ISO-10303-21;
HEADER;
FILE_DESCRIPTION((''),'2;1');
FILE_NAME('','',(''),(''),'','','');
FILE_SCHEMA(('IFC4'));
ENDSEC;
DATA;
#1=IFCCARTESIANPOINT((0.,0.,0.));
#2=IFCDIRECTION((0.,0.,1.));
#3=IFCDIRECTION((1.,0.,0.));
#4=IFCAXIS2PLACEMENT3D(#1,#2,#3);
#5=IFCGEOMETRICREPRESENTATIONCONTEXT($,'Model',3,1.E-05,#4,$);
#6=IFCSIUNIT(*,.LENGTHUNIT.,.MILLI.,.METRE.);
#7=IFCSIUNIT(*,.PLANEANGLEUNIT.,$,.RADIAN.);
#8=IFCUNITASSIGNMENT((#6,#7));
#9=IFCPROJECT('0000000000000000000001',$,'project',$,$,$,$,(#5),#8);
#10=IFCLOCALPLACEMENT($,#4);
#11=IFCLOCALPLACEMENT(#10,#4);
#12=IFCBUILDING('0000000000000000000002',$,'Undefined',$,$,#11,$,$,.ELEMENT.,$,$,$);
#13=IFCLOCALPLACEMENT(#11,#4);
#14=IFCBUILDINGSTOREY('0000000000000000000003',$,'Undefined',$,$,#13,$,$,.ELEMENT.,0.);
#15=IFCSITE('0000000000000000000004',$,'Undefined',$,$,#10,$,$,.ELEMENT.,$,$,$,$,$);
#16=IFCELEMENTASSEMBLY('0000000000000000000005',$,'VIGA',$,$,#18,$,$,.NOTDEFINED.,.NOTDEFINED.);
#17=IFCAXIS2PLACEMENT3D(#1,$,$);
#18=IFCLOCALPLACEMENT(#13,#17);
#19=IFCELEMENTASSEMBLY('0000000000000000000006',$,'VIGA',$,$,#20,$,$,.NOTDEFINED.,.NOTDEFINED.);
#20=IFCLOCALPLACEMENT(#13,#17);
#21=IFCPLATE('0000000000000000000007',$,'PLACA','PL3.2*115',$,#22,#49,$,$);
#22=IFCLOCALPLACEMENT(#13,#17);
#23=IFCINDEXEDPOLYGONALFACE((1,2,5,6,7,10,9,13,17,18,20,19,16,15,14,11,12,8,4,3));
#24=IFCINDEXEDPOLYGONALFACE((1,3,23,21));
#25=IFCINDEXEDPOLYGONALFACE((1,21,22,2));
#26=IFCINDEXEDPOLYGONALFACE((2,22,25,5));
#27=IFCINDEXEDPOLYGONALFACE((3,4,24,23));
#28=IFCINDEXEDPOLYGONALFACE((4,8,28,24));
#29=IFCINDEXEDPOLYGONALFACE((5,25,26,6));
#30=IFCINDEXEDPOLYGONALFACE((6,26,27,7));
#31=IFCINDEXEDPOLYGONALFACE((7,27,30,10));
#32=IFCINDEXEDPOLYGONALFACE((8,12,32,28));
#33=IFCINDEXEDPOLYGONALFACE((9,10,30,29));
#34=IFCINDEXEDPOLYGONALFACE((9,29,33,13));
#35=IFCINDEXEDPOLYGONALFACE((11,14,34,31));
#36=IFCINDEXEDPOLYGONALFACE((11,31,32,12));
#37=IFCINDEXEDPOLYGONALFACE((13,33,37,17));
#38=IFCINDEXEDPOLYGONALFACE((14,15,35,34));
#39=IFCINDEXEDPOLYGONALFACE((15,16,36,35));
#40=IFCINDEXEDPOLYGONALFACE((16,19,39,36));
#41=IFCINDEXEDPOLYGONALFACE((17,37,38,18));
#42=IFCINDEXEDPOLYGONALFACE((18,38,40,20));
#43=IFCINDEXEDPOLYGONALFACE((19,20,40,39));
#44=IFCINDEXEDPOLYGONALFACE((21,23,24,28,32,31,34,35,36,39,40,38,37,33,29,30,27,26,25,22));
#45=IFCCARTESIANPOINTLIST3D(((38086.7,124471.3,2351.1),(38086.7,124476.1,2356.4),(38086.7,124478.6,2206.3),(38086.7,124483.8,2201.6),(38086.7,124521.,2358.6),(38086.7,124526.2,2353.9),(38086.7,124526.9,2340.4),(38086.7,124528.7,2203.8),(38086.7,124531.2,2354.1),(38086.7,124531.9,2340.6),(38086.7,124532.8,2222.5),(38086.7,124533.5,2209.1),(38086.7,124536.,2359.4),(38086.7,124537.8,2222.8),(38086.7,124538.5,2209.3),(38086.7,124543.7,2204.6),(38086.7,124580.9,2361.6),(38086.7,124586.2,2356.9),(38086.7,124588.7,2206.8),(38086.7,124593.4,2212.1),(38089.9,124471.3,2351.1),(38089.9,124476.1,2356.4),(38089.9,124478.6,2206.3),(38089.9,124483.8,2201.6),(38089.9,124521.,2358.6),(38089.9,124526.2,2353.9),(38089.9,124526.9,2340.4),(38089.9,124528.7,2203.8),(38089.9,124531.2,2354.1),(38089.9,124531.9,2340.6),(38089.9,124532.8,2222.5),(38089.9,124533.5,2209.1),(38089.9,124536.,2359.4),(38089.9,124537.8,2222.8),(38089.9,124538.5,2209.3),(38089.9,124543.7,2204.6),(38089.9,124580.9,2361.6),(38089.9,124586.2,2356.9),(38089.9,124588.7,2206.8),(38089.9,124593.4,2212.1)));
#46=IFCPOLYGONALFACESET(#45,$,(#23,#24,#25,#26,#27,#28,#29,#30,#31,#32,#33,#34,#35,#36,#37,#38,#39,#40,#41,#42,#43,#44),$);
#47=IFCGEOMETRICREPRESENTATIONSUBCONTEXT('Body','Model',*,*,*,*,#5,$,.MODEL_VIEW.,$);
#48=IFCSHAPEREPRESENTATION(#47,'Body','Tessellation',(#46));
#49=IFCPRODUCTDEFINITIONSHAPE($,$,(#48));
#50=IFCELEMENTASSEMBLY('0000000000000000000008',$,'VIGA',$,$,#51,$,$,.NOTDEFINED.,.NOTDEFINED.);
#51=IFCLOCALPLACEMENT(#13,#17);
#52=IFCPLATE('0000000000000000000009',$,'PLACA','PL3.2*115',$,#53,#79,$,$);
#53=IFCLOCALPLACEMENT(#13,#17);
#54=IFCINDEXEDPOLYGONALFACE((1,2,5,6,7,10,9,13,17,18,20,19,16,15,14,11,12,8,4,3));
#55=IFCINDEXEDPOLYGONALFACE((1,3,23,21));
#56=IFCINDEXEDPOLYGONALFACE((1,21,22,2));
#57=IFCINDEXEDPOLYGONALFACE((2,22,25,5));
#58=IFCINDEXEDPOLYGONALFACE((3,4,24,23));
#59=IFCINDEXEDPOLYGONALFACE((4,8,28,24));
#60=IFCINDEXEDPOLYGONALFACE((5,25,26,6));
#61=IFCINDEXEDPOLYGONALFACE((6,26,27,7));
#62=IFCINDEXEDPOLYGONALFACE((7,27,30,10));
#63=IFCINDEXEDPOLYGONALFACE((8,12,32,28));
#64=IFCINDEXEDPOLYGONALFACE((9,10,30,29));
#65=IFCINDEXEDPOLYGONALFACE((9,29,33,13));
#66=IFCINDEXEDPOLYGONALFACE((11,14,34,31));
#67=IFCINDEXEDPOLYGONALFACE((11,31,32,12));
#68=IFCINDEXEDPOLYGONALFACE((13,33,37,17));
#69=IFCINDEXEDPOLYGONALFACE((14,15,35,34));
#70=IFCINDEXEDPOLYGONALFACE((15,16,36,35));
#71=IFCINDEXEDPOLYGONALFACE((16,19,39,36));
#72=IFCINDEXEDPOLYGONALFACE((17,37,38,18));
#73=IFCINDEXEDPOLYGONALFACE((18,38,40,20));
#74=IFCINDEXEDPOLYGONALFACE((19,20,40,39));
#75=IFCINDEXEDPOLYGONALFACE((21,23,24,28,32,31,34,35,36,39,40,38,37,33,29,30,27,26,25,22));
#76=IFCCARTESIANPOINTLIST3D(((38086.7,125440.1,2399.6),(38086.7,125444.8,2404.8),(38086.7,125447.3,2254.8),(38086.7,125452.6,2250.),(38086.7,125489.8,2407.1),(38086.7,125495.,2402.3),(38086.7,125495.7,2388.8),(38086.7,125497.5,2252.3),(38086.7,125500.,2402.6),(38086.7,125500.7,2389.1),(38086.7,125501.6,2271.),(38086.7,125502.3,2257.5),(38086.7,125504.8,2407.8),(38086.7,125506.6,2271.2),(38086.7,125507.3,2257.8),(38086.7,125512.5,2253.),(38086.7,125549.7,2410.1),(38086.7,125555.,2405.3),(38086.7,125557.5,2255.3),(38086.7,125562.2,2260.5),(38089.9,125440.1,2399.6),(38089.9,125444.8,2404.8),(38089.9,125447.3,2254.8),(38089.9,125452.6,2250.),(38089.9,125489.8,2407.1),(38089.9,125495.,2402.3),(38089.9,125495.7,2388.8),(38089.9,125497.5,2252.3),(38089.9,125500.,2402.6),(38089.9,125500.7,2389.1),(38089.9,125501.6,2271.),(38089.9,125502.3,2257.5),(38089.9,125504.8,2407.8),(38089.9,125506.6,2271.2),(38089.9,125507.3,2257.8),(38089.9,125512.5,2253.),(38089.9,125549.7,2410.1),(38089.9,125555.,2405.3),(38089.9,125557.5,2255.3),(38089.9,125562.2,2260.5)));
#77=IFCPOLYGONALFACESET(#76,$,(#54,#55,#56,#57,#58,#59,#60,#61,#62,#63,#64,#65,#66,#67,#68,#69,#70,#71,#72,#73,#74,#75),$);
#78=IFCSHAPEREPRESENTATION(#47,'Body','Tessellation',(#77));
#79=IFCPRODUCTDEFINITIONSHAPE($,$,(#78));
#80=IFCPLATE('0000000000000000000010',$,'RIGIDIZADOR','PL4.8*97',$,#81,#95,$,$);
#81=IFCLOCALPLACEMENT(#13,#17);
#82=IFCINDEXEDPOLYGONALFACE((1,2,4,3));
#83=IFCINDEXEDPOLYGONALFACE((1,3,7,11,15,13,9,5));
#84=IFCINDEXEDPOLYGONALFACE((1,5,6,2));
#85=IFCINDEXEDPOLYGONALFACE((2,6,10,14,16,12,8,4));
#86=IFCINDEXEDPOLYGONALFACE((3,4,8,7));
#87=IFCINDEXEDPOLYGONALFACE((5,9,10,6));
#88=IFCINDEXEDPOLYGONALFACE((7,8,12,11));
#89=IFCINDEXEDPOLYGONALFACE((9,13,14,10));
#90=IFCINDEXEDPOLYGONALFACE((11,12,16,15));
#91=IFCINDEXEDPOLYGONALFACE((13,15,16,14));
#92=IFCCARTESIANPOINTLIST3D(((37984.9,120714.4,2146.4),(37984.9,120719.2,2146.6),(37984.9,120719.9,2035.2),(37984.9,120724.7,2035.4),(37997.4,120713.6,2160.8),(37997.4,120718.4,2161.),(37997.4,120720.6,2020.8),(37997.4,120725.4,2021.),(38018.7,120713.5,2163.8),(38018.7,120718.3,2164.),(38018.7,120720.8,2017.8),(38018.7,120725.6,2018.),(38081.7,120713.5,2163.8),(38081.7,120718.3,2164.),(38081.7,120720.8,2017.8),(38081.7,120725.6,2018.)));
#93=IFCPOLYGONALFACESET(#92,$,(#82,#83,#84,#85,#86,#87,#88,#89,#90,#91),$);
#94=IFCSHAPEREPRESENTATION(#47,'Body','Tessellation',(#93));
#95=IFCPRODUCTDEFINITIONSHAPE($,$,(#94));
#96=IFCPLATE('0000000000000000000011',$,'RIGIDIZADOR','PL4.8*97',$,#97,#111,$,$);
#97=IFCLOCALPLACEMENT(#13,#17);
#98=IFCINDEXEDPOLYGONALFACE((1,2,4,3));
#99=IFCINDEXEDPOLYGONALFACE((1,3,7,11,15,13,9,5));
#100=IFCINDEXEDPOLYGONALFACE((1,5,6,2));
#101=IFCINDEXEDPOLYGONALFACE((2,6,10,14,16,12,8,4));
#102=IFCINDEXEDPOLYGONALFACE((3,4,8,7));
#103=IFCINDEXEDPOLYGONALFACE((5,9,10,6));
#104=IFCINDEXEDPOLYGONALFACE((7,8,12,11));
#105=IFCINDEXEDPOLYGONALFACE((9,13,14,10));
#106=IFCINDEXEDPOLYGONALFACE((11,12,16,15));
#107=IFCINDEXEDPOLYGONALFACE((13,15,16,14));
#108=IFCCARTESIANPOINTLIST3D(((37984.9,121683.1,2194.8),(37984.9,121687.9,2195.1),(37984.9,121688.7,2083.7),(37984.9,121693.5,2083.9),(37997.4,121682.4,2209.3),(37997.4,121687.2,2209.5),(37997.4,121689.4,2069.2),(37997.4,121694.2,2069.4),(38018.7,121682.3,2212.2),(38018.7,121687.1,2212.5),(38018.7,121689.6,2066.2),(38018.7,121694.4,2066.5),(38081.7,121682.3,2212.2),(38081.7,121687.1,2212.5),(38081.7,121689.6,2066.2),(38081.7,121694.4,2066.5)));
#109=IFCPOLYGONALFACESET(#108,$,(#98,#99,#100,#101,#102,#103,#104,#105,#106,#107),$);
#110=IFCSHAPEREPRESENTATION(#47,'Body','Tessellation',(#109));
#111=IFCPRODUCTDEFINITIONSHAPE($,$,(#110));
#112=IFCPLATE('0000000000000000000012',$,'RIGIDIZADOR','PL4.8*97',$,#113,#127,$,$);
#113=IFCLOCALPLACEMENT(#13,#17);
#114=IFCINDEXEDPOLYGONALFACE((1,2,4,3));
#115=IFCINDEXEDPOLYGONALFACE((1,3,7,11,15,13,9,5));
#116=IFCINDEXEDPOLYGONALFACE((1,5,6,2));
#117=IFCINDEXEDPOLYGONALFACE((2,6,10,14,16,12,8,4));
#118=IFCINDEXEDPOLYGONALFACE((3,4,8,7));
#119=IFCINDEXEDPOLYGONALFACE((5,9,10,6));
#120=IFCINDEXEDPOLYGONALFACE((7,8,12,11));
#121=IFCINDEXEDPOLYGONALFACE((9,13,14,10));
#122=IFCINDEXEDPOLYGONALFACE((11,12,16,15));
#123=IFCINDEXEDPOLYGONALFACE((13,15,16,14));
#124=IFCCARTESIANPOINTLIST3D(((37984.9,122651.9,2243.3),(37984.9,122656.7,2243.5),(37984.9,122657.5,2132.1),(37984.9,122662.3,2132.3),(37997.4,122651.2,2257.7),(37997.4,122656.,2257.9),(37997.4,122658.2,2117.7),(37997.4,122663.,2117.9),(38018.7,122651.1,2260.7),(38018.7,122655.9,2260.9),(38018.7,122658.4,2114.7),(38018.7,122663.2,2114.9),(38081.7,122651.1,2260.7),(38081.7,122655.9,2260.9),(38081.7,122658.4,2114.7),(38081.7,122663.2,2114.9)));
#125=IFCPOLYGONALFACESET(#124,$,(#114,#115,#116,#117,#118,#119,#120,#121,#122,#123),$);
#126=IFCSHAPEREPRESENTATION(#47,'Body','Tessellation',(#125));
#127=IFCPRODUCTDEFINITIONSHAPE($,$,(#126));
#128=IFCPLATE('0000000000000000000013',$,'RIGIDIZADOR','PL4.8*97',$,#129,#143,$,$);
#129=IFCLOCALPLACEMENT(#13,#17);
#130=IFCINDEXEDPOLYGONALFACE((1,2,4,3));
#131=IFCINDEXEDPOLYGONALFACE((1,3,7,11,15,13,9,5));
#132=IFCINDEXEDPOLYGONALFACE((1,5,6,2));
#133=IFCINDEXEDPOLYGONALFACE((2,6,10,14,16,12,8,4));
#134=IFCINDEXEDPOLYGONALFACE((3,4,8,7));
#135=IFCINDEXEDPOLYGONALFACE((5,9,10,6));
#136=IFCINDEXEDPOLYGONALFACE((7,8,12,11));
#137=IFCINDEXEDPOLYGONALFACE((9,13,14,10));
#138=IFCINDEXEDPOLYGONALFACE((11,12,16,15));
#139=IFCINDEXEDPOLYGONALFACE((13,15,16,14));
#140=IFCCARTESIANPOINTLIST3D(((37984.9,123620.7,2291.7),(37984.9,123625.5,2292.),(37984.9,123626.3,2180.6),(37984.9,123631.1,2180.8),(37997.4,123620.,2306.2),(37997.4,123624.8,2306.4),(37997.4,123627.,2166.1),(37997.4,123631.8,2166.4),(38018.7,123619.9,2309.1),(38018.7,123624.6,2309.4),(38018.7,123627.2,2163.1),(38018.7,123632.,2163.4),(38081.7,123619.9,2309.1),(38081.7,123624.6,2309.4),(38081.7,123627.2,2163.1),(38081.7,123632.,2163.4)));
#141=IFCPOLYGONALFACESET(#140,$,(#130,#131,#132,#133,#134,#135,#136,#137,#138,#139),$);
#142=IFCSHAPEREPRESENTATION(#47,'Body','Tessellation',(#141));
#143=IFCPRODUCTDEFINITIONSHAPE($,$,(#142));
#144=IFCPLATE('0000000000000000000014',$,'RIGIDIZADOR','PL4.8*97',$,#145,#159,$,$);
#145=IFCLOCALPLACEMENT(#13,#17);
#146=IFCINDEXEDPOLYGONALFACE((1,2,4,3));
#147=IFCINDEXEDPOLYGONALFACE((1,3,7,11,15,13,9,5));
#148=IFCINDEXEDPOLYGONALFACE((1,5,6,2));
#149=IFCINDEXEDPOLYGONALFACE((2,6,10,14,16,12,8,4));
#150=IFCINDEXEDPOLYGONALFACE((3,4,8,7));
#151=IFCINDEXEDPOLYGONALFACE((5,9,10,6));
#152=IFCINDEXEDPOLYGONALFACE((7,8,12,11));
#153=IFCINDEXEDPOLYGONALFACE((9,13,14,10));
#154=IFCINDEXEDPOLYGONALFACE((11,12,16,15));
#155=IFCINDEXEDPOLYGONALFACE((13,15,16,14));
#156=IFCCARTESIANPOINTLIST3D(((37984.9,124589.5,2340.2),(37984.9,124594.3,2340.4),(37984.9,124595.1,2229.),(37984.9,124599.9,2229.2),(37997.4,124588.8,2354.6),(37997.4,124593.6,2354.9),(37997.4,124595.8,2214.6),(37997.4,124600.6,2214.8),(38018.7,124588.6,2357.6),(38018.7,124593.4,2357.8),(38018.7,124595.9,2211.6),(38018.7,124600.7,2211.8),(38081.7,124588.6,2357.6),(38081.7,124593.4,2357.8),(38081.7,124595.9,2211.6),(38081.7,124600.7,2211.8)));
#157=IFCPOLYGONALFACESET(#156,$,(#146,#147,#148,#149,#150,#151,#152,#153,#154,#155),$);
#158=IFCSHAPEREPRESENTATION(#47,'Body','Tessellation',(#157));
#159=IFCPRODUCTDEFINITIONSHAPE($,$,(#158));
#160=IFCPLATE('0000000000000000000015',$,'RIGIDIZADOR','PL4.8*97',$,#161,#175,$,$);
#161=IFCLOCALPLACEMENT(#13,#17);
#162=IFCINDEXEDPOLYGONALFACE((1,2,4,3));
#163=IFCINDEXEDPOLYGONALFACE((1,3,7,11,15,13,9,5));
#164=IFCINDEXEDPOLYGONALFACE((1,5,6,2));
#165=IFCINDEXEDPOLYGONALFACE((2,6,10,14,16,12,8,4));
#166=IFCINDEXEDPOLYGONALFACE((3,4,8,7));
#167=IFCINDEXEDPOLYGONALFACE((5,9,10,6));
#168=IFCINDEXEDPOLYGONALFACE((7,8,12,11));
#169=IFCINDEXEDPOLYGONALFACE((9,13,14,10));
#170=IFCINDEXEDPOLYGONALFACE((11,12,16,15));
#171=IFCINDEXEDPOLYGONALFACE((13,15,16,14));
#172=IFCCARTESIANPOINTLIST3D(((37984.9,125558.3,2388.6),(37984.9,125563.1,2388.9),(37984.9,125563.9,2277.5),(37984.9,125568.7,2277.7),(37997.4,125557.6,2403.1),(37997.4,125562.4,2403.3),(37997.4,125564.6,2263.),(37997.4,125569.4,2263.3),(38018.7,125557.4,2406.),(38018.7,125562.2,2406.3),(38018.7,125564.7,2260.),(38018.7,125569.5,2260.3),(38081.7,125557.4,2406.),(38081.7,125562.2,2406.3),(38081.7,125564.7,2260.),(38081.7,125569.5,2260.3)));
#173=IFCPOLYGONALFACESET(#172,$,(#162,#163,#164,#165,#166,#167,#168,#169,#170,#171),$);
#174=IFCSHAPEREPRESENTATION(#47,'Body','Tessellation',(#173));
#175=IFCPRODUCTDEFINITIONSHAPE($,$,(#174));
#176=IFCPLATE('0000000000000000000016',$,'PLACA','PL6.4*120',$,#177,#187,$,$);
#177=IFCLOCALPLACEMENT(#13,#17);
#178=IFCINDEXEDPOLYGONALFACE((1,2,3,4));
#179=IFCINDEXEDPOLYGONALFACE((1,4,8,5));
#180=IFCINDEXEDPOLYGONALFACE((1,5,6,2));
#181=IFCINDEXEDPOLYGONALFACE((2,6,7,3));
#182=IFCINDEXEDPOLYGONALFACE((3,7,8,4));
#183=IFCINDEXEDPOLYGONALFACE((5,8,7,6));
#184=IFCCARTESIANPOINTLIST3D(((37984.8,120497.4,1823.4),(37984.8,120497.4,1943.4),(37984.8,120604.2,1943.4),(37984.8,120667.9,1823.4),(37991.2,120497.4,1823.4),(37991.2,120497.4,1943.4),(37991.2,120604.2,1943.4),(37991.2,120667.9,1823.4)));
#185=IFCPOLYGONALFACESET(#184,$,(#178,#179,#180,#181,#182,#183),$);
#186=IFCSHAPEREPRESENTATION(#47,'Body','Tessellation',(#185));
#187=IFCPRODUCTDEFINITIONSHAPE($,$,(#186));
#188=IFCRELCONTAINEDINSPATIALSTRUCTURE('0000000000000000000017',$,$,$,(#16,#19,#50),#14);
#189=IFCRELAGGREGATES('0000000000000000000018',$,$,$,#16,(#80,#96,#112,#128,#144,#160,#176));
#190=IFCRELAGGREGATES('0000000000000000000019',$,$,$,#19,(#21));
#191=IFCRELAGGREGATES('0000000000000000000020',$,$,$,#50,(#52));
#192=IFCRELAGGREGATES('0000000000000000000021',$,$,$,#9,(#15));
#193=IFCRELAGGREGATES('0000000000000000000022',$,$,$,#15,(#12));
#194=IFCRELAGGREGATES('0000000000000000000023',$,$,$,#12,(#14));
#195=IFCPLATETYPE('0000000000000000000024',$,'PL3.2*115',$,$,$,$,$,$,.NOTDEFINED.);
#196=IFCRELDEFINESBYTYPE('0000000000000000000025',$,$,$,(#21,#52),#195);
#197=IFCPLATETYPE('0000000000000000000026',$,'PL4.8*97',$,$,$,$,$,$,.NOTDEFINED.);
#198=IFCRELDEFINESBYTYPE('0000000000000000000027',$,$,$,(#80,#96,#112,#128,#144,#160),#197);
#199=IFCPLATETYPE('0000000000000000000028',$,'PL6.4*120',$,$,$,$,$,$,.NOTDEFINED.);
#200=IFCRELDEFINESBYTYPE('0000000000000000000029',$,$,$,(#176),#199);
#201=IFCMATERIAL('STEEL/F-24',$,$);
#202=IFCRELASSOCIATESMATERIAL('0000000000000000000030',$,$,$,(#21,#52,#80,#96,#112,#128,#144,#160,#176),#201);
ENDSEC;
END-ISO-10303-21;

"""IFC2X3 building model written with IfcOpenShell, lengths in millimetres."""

from ifc_helpers import new_model, si_unit, frame, origin_with_axes, place, context, subcontext, project, spatial, polyline, outline, extrude, material, type_object, element, aggregate, save


model = new_model("IFC2X3")

# Units and contexts
model_context = context("Model", 3, precision=1e-05, world=origin_with_axes())
body_context = subcontext(model_context, "Body", "Model", "MODEL_VIEW")
ifc_project = project(units=[si_unit("LENGTHUNIT", "METRE", prefix="MILLI"), si_unit("PLANEANGLEUNIT", "RADIAN")], contexts=[model_context])

# Site, building, storey
site_placement = place(None, origin_with_axes())
site = spatial("IfcSite", under=ifc_project, at=site_placement, Name="Undefined", CompositionType="ELEMENT")
building_placement = place(site_placement, origin_with_axes())
building = spatial("IfcBuilding", under=site, at=building_placement, Name="Undefined", CompositionType="ELEMENT")
storey_placement = place(building_placement, origin_with_axes())
storey = spatial("IfcBuildingStorey", under=building, at=storey_placement, Name="Undefined", CompositionType="ELEMENT", Elevation=0.0)

# Element assembly
assembly_1_placement = place(storey_placement, origin_with_axes())
assembly_1 = element("IfcElementAssembly", 1, at=assembly_1_placement, inside=storey, Name="VIGA", AssemblyPlace="NOTDEFINED", PredefinedType="NOTDEFINED")
ifc_material_1 = material(Name="STEEL/F-24")

# Shared definitions
plate_type_1 = type_object("IfcPlateType", Name="PL3.2*115", PredefinedType="NOTDEFINED")

# Element assemblies, plates
assembly_2_placement = place(storey_placement, origin_with_axes())
assembly_2 = element("IfcElementAssembly", 2, at=assembly_2_placement, inside=storey, Name="VIGA", AssemblyPlace="NOTDEFINED", PredefinedType="NOTDEFINED")
plate_1_placement = place(assembly_2_placement, frame((38088.3, 124471.1, 2356.1), z_axis=(-1.0, 0.0, 0.0), x_axis=(0.0, 0.998752, 0.04995)))
plate_1 = element("IfcPlate", 3, at=plate_1_placement, type_object=plate_type_1, material=ifc_material_1, Name="PLACA", Description="PL3.2*115", context=body_context, shape_type="SweptSolid", body=[
    extrude(outline(polyline([(0.0, 5.0), (5.0, 0.0), (50.0, 0.0), (55.0, 5.0), (55.0, 18.5), (60.0, 18.5), (60.0, 5.0), (65.0, 0.0), (110.0, 0.0), (115.0, 5.0), (115.0, 150.0), (110.0, 155.0), (65.0, 155.0), (60.0, 150.0), (60.0, 136.5), (55.0, 136.5), (55.0, 150.0), (50.0, 155.0), (5.0, 155.0), (0.0, 150.0), (0.0, 5.0)])), frame((0.0, 0.0, -1.6), z_axis=(0.0, 0.0, 1.0), x_axis=(1.0, 0.0, 0.0)), (0.0, 0.0, 1.0), 3.2),
])
assembly_3_placement = place(storey_placement, origin_with_axes())
assembly_3 = element("IfcElementAssembly", 4, at=assembly_3_placement, inside=storey, Name="VIGA", AssemblyPlace="NOTDEFINED", PredefinedType="NOTDEFINED")
plate_2_placement = place(assembly_3_placement, frame((38088.3, 125439.9, 2404.6), z_axis=(-1.0, 0.0, 0.0), x_axis=(0.0, 0.998752, 0.04995)))
plate_2 = element("IfcPlate", 5, at=plate_2_placement, type_object=plate_type_1, material=ifc_material_1, Name="PLACA", Description="PL3.2*115", context=body_context, shape_type="SweptSolid", body=[
    extrude(outline(polyline([(0.0, 5.0), (5.0, 0.0), (50.0, 0.0), (55.0, 5.0), (55.0, 18.5), (60.0, 18.5), (60.0, 5.0), (65.0, 0.0), (110.0, 0.0), (115.0, 5.0), (115.0, 150.0), (110.0, 155.0), (65.0, 155.0), (60.0, 150.0), (60.0, 136.5), (55.0, 136.5), (55.0, 150.0), (50.0, 155.0), (5.0, 155.0), (0.0, 150.0), (0.0, 5.0)])), frame((0.0, 0.0, -1.6), z_axis=(0.0, 0.0, 1.0), x_axis=(1.0, 0.0, 0.0)), (0.0, 0.0, 1.0), 3.2),
])

# Plates
plate_type_2 = type_object("IfcPlateType", Name="PL4.8*97", PredefinedType="NOTDEFINED")
plate_3_placement = place(assembly_1_placement, frame((38081.7, 120715.9, 2163.9), z_axis=(0.0, -0.998752, -0.04995), x_axis=(-1.0, 0.0, 0.0)))
plate_3 = element("IfcPlate", 6, at=plate_3_placement, type_object=plate_type_2, material=ifc_material_1, Name="RIGIDIZADOR", Description="PL4.8*97", context=body_context, shape_type="SweptSolid", body=[
    extrude(outline(polyline([(0.0, 0.0), (63.0, 0.0), (84.3, 3.0), (96.8, 17.4), (96.8, 128.7), (84.3, 143.2), (63.0, 146.2), (0.0, 146.2), (0.0, 0.0)])), frame((0.0, 0.0, -2.4), z_axis=(0.0, 0.0, 1.0), x_axis=(1.0, 0.0, 0.0)), (0.0, 0.0, 1.0), 4.8),
])
plate_4_placement = place(assembly_1_placement, frame((38081.7, 121684.7, 2212.4), z_axis=(0.0, -0.998752, -0.04995), x_axis=(-1.0, 0.0, 0.0)))
plate_4 = element("IfcPlate", 7, at=plate_4_placement, type_object=plate_type_2, material=ifc_material_1, Name="RIGIDIZADOR", Description="PL4.8*97", context=body_context, shape_type="SweptSolid", body=[
    extrude(outline(polyline([(0.0, 0.0), (63.0, 0.0), (84.3, 3.0), (96.8, 17.4), (96.8, 128.7), (84.3, 143.2), (63.0, 146.2), (0.0, 146.2), (0.0, 0.0)])), frame((0.0, 0.0, -2.4), z_axis=(0.0, 0.0, 1.0), x_axis=(1.0, 0.0, 0.0)), (0.0, 0.0, 1.0), 4.8),
])
plate_5_placement = place(assembly_1_placement, frame((38081.7, 122653.5, 2260.8), z_axis=(0.0, -0.998752, -0.04995), x_axis=(-1.0, 0.0, 0.0)))
plate_5 = element("IfcPlate", 8, at=plate_5_placement, type_object=plate_type_2, material=ifc_material_1, Name="RIGIDIZADOR", Description="PL4.8*97", context=body_context, shape_type="SweptSolid", body=[
    extrude(outline(polyline([(0.0, 0.0), (63.0, 0.0), (84.3, 3.0), (96.8, 17.4), (96.8, 128.7), (84.3, 143.2), (63.0, 146.2), (0.0, 146.2), (0.0, 0.0)])), frame((0.0, 0.0, -2.4), z_axis=(0.0, 0.0, 1.0), x_axis=(1.0, 0.0, 0.0)), (0.0, 0.0, 1.0), 4.8),
])
plate_6_placement = place(assembly_1_placement, frame((38081.7, 123622.3, 2309.3), z_axis=(0.0, -0.998752, -0.04995), x_axis=(-1.0, 0.0, 0.0)))
plate_6 = element("IfcPlate", 9, at=plate_6_placement, type_object=plate_type_2, material=ifc_material_1, Name="RIGIDIZADOR", Description="PL4.8*97", context=body_context, shape_type="SweptSolid", body=[
    extrude(outline(polyline([(0.0, 0.0), (63.0, 0.0), (84.3, 3.0), (96.8, 17.4), (96.8, 128.7), (84.3, 143.2), (63.0, 146.2), (0.0, 146.2), (0.0, 0.0)])), frame((0.0, 0.0, -2.4), z_axis=(0.0, 0.0, 1.0), x_axis=(1.0, 0.0, 0.0)), (0.0, 0.0, 1.0), 4.8),
])
plate_7_placement = place(assembly_1_placement, frame((38081.7, 124591.0, 2357.7), z_axis=(0.0, -0.998752, -0.04995), x_axis=(-1.0, 0.0, 0.0)))
plate_7 = element("IfcPlate", 10, at=plate_7_placement, type_object=plate_type_2, material=ifc_material_1, Name="RIGIDIZADOR", Description="PL4.8*97", context=body_context, shape_type="SweptSolid", body=[
    extrude(outline(polyline([(0.0, 0.0), (63.0, 0.0), (84.3, 3.0), (96.8, 17.4), (96.8, 128.7), (84.3, 143.2), (63.0, 146.2), (0.0, 146.2), (0.0, 0.0)])), frame((0.0, 0.0, -2.4), z_axis=(0.0, 0.0, 1.0), x_axis=(1.0, 0.0, 0.0)), (0.0, 0.0, 1.0), 4.8),
])
plate_8_placement = place(assembly_1_placement, frame((38081.7, 125559.8, 2406.2), z_axis=(0.0, -0.998752, -0.04995), x_axis=(-1.0, 0.0, 0.0)))
plate_8 = element("IfcPlate", 11, at=plate_8_placement, type_object=plate_type_2, material=ifc_material_1, Name="RIGIDIZADOR", Description="PL4.8*97", context=body_context, shape_type="SweptSolid", body=[
    extrude(outline(polyline([(0.0, 0.0), (63.0, 0.0), (84.3, 3.0), (96.8, 17.4), (96.8, 128.7), (84.3, 143.2), (63.0, 146.2), (0.0, 146.2), (0.0, 0.0)])), frame((0.0, 0.0, -2.4), z_axis=(0.0, 0.0, 1.0), x_axis=(1.0, 0.0, 0.0)), (0.0, 0.0, 1.0), 4.8),
])
plate_type_3 = type_object("IfcPlateType", Name="PL6.4*120", PredefinedType="NOTDEFINED")
plate_9_placement = place(assembly_1_placement, frame((37988.0, 120604.2, 1943.4), z_axis=(1.0, 0.0, 0.0), x_axis=(0.0, -1.0, 0.0)))
plate_9 = element("IfcPlate", 12, at=plate_9_placement, type_object=plate_type_3, material=ifc_material_1, Name="PLACA", Description="PL6.4*120", context=body_context, shape_type="SweptSolid", body=[
    extrude(outline(polyline([(0.0, 0.0), (106.8, 0.0), (106.8, 120.0), (-63.7, 120.0), (0.0, 0.0)])), frame((0.0, 0.0, -3.2), z_axis=(0.0, 0.0, 1.0), x_axis=(1.0, 0.0, 0.0)), (0.0, 0.0, 1.0), 6.4),
])
aggregate(assembly_1, [plate_3, plate_4, plate_5, plate_6, plate_7, plate_8, plate_9])

aggregate(assembly_2, [plate_1])
aggregate(assembly_3, [plate_2])

save(model, "model.ifc")
